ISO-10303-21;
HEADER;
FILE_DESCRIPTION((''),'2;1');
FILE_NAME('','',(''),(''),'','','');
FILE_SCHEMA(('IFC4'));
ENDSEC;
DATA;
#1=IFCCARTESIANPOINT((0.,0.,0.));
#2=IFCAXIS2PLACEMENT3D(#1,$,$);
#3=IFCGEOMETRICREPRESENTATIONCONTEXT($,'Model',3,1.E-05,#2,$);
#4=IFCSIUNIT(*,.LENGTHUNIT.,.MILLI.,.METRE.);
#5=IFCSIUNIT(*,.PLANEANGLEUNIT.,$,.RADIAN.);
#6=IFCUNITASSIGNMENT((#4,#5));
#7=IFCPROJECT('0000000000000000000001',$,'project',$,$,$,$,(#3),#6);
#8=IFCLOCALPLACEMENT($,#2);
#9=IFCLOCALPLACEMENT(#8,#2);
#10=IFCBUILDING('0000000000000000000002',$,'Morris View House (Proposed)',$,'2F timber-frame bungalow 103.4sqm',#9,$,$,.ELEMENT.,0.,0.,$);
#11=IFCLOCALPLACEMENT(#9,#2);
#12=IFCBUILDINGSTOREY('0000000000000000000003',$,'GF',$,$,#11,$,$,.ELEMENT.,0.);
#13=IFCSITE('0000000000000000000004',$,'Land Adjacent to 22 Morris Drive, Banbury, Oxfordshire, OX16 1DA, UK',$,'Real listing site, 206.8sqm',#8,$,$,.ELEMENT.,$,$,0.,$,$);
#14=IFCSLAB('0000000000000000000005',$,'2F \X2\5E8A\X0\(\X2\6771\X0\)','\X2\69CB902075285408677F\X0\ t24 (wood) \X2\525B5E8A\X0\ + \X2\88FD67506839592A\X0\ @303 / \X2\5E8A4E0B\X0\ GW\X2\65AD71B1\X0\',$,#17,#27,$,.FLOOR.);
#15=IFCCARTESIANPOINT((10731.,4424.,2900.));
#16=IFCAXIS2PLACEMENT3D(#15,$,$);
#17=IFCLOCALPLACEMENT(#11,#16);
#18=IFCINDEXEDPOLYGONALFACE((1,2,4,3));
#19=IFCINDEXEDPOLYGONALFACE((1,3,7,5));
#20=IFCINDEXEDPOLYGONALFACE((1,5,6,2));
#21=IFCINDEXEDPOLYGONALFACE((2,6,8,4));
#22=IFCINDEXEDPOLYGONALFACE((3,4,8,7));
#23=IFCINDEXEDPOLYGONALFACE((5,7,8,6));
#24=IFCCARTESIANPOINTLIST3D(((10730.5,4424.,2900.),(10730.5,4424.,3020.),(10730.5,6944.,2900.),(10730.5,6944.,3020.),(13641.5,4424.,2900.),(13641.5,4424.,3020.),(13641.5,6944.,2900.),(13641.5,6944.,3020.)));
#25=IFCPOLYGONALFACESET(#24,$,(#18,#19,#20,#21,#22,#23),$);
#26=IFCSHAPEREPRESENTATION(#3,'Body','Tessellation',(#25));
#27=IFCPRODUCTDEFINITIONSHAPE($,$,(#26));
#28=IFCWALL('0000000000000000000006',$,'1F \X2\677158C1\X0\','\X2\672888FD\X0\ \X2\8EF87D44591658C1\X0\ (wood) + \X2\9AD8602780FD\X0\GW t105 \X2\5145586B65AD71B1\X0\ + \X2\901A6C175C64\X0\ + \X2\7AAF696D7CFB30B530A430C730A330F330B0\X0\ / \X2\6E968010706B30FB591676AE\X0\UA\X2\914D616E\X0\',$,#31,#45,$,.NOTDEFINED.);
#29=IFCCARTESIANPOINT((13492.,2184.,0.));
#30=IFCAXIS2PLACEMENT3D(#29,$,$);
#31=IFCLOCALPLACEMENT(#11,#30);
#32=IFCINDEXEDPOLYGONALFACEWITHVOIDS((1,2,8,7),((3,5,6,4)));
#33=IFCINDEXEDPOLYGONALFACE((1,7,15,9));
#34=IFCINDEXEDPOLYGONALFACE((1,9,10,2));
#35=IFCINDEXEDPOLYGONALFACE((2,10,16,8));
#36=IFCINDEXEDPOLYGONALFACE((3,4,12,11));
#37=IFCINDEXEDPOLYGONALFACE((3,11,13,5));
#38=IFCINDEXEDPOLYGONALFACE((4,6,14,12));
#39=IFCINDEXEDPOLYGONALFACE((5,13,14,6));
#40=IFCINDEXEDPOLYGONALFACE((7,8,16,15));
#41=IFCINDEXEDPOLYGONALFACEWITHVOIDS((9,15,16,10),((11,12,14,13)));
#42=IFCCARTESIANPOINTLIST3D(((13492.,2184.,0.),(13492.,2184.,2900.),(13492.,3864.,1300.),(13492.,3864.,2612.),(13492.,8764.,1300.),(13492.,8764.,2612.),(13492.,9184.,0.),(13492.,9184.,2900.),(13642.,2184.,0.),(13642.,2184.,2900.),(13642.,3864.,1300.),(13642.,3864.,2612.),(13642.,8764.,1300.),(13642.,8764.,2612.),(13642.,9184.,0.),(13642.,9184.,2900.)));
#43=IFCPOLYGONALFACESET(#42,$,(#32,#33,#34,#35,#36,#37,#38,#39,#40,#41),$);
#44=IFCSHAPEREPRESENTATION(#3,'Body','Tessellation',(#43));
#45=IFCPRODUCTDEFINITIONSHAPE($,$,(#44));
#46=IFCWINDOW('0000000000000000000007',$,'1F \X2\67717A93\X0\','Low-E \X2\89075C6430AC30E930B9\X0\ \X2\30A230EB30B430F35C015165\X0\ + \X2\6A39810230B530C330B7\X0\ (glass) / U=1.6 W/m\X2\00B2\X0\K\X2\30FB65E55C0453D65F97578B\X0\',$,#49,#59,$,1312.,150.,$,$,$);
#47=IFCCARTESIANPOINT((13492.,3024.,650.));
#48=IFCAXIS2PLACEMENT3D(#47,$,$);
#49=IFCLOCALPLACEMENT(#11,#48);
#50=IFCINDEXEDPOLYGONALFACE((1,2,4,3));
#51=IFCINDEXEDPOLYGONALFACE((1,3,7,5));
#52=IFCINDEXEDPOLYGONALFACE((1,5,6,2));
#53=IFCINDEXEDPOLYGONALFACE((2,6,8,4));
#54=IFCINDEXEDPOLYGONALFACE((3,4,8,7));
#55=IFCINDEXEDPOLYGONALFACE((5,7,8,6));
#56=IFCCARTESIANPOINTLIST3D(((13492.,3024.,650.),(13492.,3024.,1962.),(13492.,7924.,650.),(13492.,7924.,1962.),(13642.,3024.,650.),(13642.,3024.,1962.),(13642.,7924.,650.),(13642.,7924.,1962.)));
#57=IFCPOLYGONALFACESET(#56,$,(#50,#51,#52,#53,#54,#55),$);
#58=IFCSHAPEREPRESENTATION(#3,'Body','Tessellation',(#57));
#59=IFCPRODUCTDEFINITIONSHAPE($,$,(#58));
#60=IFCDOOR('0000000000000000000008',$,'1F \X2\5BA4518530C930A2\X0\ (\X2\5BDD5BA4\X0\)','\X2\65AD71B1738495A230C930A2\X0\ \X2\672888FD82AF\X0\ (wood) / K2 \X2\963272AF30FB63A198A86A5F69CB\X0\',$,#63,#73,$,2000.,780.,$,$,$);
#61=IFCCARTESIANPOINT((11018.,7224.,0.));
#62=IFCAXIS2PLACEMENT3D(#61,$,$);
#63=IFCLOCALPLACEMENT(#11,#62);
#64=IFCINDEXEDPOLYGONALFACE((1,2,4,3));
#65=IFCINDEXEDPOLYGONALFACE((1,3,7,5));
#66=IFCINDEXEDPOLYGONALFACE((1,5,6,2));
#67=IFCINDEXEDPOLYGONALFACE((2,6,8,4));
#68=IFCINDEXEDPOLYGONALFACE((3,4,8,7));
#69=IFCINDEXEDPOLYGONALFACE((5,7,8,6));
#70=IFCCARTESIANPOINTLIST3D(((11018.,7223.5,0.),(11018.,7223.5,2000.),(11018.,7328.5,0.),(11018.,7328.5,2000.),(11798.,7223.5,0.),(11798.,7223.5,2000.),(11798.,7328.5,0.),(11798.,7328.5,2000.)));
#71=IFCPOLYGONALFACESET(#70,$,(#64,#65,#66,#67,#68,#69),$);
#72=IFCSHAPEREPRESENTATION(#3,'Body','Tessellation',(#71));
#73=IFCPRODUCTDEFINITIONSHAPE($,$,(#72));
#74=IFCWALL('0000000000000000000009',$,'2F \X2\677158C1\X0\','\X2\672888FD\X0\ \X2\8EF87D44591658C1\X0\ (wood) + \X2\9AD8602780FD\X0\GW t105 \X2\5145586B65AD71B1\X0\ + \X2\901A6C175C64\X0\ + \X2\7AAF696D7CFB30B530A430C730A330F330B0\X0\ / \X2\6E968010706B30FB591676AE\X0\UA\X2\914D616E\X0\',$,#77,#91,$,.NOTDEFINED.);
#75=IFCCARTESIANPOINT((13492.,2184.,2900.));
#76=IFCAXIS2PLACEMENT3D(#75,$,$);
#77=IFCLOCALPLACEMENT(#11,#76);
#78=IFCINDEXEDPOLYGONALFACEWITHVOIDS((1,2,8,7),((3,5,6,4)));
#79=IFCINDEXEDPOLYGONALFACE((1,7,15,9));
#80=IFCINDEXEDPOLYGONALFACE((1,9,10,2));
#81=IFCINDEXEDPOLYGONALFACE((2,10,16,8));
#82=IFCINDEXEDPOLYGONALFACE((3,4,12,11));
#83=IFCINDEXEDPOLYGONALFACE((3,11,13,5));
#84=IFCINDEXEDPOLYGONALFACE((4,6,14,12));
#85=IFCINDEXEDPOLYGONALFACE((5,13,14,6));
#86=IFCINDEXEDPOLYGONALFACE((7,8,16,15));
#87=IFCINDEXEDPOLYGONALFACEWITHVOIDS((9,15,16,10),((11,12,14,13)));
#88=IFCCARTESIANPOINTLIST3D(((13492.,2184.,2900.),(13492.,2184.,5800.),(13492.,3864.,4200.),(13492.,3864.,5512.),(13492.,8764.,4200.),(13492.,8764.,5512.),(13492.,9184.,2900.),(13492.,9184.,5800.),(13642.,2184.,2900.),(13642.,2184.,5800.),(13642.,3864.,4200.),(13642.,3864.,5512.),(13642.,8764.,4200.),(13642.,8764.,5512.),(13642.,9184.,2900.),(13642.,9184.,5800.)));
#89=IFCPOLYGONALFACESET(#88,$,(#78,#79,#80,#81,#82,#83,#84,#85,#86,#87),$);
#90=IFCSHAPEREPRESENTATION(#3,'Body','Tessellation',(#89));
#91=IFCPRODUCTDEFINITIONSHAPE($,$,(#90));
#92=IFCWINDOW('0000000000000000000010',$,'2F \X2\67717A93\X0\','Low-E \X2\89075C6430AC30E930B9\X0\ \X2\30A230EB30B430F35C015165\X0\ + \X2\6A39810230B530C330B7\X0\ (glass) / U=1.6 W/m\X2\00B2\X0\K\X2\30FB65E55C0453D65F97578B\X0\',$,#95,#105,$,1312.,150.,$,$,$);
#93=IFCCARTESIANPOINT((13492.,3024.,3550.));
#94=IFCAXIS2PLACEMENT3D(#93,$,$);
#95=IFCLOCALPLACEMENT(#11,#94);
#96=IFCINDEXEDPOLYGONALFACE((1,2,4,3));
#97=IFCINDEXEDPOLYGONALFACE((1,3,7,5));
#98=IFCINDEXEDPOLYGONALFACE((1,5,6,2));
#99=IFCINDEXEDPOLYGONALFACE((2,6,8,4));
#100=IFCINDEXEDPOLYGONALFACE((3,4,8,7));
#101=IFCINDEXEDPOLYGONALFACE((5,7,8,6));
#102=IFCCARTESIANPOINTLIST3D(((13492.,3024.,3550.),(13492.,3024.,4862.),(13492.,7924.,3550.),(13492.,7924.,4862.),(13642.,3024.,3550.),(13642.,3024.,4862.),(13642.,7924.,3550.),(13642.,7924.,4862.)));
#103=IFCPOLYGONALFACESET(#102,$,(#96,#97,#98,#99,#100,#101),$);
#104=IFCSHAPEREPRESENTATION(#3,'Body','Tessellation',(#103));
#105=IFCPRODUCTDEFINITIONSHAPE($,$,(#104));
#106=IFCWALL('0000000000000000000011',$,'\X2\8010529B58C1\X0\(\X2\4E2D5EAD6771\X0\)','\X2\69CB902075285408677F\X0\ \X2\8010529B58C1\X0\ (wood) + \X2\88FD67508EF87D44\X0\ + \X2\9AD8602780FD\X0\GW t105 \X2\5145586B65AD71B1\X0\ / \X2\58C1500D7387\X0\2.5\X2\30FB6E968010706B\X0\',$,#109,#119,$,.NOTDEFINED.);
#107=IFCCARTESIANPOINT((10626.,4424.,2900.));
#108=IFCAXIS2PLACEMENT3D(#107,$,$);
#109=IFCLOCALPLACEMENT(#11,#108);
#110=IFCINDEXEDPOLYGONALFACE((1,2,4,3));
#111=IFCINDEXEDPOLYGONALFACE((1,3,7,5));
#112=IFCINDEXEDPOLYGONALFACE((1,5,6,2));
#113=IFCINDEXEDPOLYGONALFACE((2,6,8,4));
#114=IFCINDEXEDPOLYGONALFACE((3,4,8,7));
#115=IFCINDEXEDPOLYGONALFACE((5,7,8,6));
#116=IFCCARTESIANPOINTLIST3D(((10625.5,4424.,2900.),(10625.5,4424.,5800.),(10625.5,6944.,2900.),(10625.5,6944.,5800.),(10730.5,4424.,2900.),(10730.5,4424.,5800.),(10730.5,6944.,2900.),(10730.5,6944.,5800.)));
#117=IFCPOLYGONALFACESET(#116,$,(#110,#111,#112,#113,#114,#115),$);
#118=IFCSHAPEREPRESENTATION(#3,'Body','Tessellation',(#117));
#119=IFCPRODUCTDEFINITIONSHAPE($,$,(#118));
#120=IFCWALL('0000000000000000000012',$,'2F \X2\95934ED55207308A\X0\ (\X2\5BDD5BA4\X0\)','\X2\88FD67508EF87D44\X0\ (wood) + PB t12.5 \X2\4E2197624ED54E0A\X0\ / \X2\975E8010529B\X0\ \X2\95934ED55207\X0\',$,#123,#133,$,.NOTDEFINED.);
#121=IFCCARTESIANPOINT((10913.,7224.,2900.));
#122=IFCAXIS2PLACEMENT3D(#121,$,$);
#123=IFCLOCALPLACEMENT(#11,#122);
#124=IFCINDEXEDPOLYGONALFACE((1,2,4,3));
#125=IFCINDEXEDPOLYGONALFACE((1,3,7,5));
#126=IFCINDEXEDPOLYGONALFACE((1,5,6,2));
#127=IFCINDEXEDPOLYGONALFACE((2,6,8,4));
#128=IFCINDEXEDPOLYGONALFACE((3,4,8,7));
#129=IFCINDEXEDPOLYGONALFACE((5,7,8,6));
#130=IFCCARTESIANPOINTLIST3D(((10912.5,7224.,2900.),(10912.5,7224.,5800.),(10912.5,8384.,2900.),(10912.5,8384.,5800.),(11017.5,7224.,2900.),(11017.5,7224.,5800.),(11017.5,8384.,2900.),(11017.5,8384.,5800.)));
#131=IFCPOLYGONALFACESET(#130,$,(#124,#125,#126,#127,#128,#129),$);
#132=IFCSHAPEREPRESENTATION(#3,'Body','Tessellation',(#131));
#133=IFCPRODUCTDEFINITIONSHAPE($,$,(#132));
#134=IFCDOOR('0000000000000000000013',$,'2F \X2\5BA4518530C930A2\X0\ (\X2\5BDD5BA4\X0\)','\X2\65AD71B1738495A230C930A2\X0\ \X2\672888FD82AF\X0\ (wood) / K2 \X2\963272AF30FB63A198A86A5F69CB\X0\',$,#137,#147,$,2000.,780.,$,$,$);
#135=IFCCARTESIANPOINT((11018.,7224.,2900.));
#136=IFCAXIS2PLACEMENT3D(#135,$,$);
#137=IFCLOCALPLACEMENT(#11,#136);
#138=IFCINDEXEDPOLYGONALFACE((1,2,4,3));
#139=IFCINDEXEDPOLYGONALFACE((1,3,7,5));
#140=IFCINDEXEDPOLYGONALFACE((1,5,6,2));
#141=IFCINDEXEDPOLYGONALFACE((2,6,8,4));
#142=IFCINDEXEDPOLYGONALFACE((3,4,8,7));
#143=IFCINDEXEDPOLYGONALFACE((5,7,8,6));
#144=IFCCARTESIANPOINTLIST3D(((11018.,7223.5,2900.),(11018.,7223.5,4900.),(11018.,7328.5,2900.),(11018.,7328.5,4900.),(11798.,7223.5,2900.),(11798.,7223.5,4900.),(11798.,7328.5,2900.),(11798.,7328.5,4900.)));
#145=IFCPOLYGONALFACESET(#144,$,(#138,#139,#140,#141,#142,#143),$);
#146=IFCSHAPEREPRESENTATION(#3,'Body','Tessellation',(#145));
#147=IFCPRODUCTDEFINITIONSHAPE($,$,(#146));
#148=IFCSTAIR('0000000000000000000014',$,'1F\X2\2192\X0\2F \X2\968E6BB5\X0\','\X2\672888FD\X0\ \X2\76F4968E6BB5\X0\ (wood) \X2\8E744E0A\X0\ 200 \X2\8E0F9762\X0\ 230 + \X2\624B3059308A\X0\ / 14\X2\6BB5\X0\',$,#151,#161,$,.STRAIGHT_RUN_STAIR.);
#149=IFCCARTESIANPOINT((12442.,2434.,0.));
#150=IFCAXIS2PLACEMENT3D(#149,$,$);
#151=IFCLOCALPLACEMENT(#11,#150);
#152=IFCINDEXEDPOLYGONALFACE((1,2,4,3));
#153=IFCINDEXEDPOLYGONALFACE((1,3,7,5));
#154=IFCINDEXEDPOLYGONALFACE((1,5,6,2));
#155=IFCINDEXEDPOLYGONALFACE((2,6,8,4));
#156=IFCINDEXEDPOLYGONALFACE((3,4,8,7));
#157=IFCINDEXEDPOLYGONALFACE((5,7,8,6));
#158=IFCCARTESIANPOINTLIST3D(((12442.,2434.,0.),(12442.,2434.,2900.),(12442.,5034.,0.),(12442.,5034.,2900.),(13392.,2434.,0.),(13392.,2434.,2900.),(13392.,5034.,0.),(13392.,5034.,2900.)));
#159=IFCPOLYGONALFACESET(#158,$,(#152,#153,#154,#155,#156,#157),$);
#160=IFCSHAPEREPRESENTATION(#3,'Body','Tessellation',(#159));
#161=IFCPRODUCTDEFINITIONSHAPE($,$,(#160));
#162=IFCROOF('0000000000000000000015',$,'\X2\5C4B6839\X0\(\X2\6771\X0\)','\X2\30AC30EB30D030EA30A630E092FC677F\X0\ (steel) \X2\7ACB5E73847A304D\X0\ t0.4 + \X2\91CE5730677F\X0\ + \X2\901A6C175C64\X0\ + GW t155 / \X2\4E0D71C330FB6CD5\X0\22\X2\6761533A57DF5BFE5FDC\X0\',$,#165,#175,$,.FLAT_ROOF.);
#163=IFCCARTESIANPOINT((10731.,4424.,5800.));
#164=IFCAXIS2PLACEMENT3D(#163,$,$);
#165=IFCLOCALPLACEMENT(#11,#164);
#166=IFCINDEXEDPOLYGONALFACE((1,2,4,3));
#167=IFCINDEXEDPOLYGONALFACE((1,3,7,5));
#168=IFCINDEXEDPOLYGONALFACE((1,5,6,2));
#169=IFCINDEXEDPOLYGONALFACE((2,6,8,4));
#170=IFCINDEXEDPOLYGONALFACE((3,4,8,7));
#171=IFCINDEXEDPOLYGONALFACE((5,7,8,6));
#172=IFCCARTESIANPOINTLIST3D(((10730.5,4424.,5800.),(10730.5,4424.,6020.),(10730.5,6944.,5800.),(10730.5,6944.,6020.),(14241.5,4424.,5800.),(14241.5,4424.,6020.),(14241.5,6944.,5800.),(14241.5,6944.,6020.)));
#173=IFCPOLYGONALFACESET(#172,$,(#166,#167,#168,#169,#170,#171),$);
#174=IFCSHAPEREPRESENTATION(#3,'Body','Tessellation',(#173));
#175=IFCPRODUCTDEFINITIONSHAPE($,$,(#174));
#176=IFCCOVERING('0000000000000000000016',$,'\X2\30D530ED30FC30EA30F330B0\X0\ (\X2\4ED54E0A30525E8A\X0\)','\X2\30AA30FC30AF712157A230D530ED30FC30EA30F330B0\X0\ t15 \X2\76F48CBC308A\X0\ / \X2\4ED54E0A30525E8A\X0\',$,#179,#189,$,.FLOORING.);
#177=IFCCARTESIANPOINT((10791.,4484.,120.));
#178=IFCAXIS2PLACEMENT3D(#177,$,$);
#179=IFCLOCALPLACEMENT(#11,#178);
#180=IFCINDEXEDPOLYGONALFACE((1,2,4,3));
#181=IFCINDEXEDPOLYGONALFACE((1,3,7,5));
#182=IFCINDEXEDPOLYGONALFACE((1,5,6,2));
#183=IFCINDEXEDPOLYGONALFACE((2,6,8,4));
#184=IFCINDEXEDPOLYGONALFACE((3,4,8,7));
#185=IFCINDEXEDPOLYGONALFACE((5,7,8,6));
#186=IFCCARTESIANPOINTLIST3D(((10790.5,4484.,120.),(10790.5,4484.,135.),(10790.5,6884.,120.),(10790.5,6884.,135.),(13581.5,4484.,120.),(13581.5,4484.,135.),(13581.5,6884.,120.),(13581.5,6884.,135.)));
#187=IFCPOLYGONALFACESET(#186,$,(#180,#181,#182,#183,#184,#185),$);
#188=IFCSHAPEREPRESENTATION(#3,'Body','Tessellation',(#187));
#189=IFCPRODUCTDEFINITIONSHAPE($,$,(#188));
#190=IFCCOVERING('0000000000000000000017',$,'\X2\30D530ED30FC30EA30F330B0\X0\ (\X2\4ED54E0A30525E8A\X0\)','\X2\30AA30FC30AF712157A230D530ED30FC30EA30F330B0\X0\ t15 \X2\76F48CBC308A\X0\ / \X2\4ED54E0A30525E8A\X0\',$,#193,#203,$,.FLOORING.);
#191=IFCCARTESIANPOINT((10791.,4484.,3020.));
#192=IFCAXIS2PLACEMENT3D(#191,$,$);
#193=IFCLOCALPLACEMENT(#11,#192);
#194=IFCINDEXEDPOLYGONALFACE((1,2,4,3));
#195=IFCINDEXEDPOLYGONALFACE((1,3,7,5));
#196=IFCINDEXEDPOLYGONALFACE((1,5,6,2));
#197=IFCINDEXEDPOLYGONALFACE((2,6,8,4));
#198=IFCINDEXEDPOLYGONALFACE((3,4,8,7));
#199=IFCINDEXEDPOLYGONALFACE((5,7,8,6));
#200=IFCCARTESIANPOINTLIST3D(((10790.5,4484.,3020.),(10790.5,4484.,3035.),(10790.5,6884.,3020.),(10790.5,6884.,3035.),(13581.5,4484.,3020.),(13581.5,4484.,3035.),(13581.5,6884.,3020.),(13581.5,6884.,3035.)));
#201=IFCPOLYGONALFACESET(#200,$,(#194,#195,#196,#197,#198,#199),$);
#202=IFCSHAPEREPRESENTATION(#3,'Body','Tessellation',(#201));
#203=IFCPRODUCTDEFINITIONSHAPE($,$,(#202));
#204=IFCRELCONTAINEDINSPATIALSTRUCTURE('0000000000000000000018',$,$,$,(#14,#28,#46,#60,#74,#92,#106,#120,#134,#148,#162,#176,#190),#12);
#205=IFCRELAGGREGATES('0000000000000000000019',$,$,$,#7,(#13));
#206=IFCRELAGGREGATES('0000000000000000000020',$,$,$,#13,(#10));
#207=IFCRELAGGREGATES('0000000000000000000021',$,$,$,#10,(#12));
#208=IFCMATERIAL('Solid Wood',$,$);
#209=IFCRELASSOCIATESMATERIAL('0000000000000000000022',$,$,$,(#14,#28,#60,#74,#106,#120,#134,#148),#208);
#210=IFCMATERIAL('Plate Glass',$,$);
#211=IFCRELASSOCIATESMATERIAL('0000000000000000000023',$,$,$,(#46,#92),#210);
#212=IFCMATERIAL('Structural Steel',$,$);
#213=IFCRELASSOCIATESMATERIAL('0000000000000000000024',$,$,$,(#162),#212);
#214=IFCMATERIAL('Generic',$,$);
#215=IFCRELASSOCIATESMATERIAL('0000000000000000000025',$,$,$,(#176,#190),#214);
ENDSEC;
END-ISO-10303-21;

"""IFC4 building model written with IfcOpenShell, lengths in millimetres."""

from ifc_helpers import new_model, si_unit, frame, frame_2d, origin, place, context, project, spatial, rectangle, extrude, material, element, fill, save


model = new_model("IFC4")

# Units and contexts
model_context = context("Model", 3, precision=1e-05, world=origin())
ifc_project = project(units=[si_unit("LENGTHUNIT", "METRE", prefix="MILLI"), si_unit("PLANEANGLEUNIT", "RADIAN")], contexts=[model_context])

# Site, building, storey
site_placement = place(None, origin())
site = spatial("IfcSite", under=ifc_project, at=site_placement, Name="Land Adjacent to 22 Morris Drive, Banbury, Oxfordshire, OX16 1DA, UK", ObjectType="Real listing site, 206.8sqm", CompositionType="ELEMENT", RefElevation=0.0)
building_placement = place(site_placement, origin())
building = spatial("IfcBuilding", under=site, at=building_placement, Name="Morris View House (Proposed)", ObjectType="2F timber-frame bungalow 103.4sqm", CompositionType="ELEMENT", ElevationOfRefHeight=0.0, ElevationOfTerrain=0.0)
storey_placement = place(building_placement, origin())
storey = spatial("IfcBuildingStorey", under=building, at=storey_placement, Name="GF", CompositionType="ELEMENT", Elevation=0.0)

# Slab
ifc_material_1 = material(Name="Solid Wood")
slab_1_placement = place(storey_placement, frame((10731.0, 4424.0, 2900.0)))
element("IfcSlab", 1, at=slab_1_placement, inside=storey, material=ifc_material_1, Name="2F 床(東)", Description="構造用合板 t24 (wood) 剛床 + 製材根太 @303 / 床下 GW断熱", PredefinedType="FLOOR", context=model_context, shape_type="SweptSolid", body=[
    extrude(rectangle(XDim=2911.0, YDim=2520.0, at=frame_2d((1455.0, 1260.0))), frame((10731.0, 4424.0, 2900.0)), (0.0, 0.0, 1.0), 120.0),
])

# Wall, opening, window
wall_1_placement = place(storey_placement, frame((13492.0, 2184.0, 0.0)))
wall_1 = element("IfcWall", 2, at=wall_1_placement, inside=storey, material=ifc_material_1, Name="1F 東壁", Description="木製 軸組外壁 (wood) + 高性能GW t105 充填断熱 + 通気層 + 窯業系サイディング / 準耐火・外皮UA配慮", PredefinedType="NOTDEFINED", context=model_context, shape_type="SweptSolid", body=[
    extrude(rectangle(XDim=150.0, YDim=7000.0, at=frame_2d((75.0, 3500.0))), frame((13492.0, 2184.0, 0.0)), (0.0, 0.0, 1.0), 2900.0),
])
opening_1_placement = place(storey_placement, frame((13492.0, 3024.0, 650.0)))
opening_1 = element("IfcOpeningElement", 3, at=opening_1_placement, cuts=wall_1, PredefinedType="NOTDEFINED", context=model_context, shape_type="SweptSolid", body=[
    extrude(rectangle(XDim=150.0, YDim=4900.0, at=frame_2d((75.0, 2450.0))), frame((13492.0, 3024.0, 650.0)), (0.0, 0.0, 1.0), 1312.0),
])
ifc_material_2 = material(Name="Plate Glass")
window_1_placement = place(storey_placement, frame((13492.0, 3024.0, 650.0)))
window_1 = element("IfcWindow", 4, at=window_1_placement, inside=storey, material=ifc_material_2, Name="1F 東窓", Description="Low-E 複層ガラス アルゴン封入 + 樹脂サッシ (glass) / U=1.6 W/m²K・日射取得型", OverallHeight=1312.0, OverallWidth=150.0, context=model_context, shape_type="SweptSolid", body=[
    extrude(rectangle(XDim=150.0, YDim=4900.0, at=frame_2d((75.0, 2450.0))), frame((13492.0, 3024.0, 650.0)), (0.0, 0.0, 1.0), 1312.0),
])
fill(opening_1, window_1)

# Door
door_1_placement = place(storey_placement, frame((11018.0, 7224.0, 0.0)))
element("IfcDoor", 5, at=door_1_placement, inside=storey, material=ifc_material_1, Name="1F 室内ドア (寝室)", Description="断熱玄関ドア 木製芯 (wood) / K2 防犯・採風機構", OverallHeight=2000.0, OverallWidth=780.0, context=model_context, shape_type="SweptSolid", body=[
    extrude(rectangle(XDim=780.0, YDim=105.0, at=frame_2d((390.0, 52.0))), frame((11018.0, 7224.0, 0.0)), (0.0, 0.0, 1.0), 2000.0),
])

# Wall, opening, window
wall_2_placement = place(storey_placement, frame((13492.0, 2184.0, 2900.0)))
wall_2 = element("IfcWall", 6, at=wall_2_placement, inside=storey, material=ifc_material_1, Name="2F 東壁", Description="木製 軸組外壁 (wood) + 高性能GW t105 充填断熱 + 通気層 + 窯業系サイディング / 準耐火・外皮UA配慮", PredefinedType="NOTDEFINED", context=model_context, shape_type="SweptSolid", body=[
    extrude(rectangle(XDim=150.0, YDim=7000.0, at=frame_2d((75.0, 3500.0))), frame((13492.0, 2184.0, 2900.0)), (0.0, 0.0, 1.0), 2900.0),
])
opening_2_placement = place(storey_placement, frame((13492.0, 3024.0, 3550.0)))
opening_2 = element("IfcOpeningElement", 7, at=opening_2_placement, cuts=wall_2, PredefinedType="NOTDEFINED", context=model_context, shape_type="SweptSolid", body=[
    extrude(rectangle(XDim=150.0, YDim=4900.0, at=frame_2d((75.0, 2450.0))), frame((13492.0, 3024.0, 3550.0)), (0.0, 0.0, 1.0), 1312.0),
])
window_2_placement = place(storey_placement, frame((13492.0, 3024.0, 3550.0)))
window_2 = element("IfcWindow", 8, at=window_2_placement, inside=storey, material=ifc_material_2, Name="2F 東窓", Description="Low-E 複層ガラス アルゴン封入 + 樹脂サッシ (glass) / U=1.6 W/m²K・日射取得型", OverallHeight=1312.0, OverallWidth=150.0, context=model_context, shape_type="SweptSolid", body=[
    extrude(rectangle(XDim=150.0, YDim=4900.0, at=frame_2d((75.0, 2450.0))), frame((13492.0, 3024.0, 3550.0)), (0.0, 0.0, 1.0), 1312.0),
])
fill(opening_2, window_2)

# Walls
wall_3_placement = place(storey_placement, frame((10626.0, 4424.0, 2900.0)))
element("IfcWall", 9, at=wall_3_placement, inside=storey, material=ifc_material_1, Name="耐力壁(中庭東)", Description="構造用合板 耐力壁 (wood) + 製材軸組 + 高性能GW t105 充填断熱 / 壁倍率2.5・準耐火", PredefinedType="NOTDEFINED", context=model_context, shape_type="SweptSolid", body=[
    extrude(rectangle(XDim=105.0, YDim=2520.0, at=frame_2d((52.0, 1260.0))), frame((10626.0, 4424.0, 2900.0)), (0.0, 0.0, 1.0), 2900.0),
])
wall_4_placement = place(storey_placement, frame((10913.0, 7224.0, 2900.0)))
element("IfcWall", 10, at=wall_4_placement, inside=storey, material=ifc_material_1, Name="2F 間仕切り (寝室)", Description="製材軸組 (wood) + PB t12.5 両面仕上 / 非耐力 間仕切", PredefinedType="NOTDEFINED", context=model_context, shape_type="SweptSolid", body=[
    extrude(rectangle(XDim=105.0, YDim=1160.0, at=frame_2d((52.0, 580.0))), frame((10913.0, 7224.0, 2900.0)), (0.0, 0.0, 1.0), 2900.0),
])

# Door
door_2_placement = place(storey_placement, frame((11018.0, 7224.0, 2900.0)))
element("IfcDoor", 11, at=door_2_placement, inside=storey, material=ifc_material_1, Name="2F 室内ドア (寝室)", Description="断熱玄関ドア 木製芯 (wood) / K2 防犯・採風機構", OverallHeight=2000.0, OverallWidth=780.0, context=model_context, shape_type="SweptSolid", body=[
    extrude(rectangle(XDim=780.0, YDim=105.0, at=frame_2d((390.0, 52.0))), frame((11018.0, 7224.0, 2900.0)), (0.0, 0.0, 1.0), 2000.0),
])

# Stair
stair_placement = place(storey_placement, frame((12442.0, 2434.0, 0.0)))
element("IfcStair", 12, at=stair_placement, inside=storey, material=ifc_material_1, Name="1F→2F 階段", Description="木製 直階段 (wood) 蹴上 200 踏面 230 + 手すり / 14段", PredefinedType="STRAIGHT_RUN_STAIR", context=model_context, shape_type="SweptSolid", body=[
    extrude(rectangle(XDim=950.0, YDim=2600.0, at=frame_2d((475.0, 1300.0))), frame((12442.0, 2434.0, 0.0)), (0.0, 0.0, 1.0), 2900.0),
])

# Roof
ifc_material_3 = material(Name="Structural Steel")
for number, where, name in (
    (13, (10731.0, 4424.0, 5800.0), "屋根(東)"),
):
    element("IfcRoof", number, at=place(storey_placement, frame(where)), inside=storey, material=ifc_material_3, Name=name, Description="ガルバリウム鋼板 (steel) 立平葺き t0.4 + 野地板 + 通気層 + GW t155 / 不燃・法22条区域対応", PredefinedType="FLAT_ROOF", context=model_context, shape_type="SweptSolid", body=[
        extrude(rectangle(XDim=3511.0, YDim=2520.0, at=frame_2d((1755.0, 1260.0))), frame((10731.0, 4424.0, 5800.0)), (0.0, 0.0, 1.0), 220.0),
    ])

# Coverings
ifc_material_4 = material(Name="Generic")
covering_1_placement = place(storey_placement, frame((10791.0, 4484.0, 120.0)))
element("IfcCovering", 14, at=covering_1_placement, inside=storey, material=ifc_material_4, Name="フローリング (仕上げ床)", Description="オーク無垢フローリング t15 直貼り / 仕上げ床", PredefinedType="FLOORING", context=model_context, shape_type="SweptSolid", body=[
    extrude(rectangle(XDim=2791.0, YDim=2400.0, at=frame_2d((1395.0, 1200.0))), frame((10791.0, 4484.0, 120.0)), (0.0, 0.0, 1.0), 15.0),
])
covering_2_placement = place(storey_placement, frame((10791.0, 4484.0, 3020.0)))
element("IfcCovering", 15, at=covering_2_placement, inside=storey, material=ifc_material_4, Name="フローリング (仕上げ床)", Description="オーク無垢フローリング t15 直貼り / 仕上げ床", PredefinedType="FLOORING", context=model_context, shape_type="SweptSolid", body=[
    extrude(rectangle(XDim=2791.0, YDim=2400.0, at=frame_2d((1395.0, 1200.0))), frame((10791.0, 4484.0, 3020.0)), (0.0, 0.0, 1.0), 15.0),
])

save(model, "model.ifc")
